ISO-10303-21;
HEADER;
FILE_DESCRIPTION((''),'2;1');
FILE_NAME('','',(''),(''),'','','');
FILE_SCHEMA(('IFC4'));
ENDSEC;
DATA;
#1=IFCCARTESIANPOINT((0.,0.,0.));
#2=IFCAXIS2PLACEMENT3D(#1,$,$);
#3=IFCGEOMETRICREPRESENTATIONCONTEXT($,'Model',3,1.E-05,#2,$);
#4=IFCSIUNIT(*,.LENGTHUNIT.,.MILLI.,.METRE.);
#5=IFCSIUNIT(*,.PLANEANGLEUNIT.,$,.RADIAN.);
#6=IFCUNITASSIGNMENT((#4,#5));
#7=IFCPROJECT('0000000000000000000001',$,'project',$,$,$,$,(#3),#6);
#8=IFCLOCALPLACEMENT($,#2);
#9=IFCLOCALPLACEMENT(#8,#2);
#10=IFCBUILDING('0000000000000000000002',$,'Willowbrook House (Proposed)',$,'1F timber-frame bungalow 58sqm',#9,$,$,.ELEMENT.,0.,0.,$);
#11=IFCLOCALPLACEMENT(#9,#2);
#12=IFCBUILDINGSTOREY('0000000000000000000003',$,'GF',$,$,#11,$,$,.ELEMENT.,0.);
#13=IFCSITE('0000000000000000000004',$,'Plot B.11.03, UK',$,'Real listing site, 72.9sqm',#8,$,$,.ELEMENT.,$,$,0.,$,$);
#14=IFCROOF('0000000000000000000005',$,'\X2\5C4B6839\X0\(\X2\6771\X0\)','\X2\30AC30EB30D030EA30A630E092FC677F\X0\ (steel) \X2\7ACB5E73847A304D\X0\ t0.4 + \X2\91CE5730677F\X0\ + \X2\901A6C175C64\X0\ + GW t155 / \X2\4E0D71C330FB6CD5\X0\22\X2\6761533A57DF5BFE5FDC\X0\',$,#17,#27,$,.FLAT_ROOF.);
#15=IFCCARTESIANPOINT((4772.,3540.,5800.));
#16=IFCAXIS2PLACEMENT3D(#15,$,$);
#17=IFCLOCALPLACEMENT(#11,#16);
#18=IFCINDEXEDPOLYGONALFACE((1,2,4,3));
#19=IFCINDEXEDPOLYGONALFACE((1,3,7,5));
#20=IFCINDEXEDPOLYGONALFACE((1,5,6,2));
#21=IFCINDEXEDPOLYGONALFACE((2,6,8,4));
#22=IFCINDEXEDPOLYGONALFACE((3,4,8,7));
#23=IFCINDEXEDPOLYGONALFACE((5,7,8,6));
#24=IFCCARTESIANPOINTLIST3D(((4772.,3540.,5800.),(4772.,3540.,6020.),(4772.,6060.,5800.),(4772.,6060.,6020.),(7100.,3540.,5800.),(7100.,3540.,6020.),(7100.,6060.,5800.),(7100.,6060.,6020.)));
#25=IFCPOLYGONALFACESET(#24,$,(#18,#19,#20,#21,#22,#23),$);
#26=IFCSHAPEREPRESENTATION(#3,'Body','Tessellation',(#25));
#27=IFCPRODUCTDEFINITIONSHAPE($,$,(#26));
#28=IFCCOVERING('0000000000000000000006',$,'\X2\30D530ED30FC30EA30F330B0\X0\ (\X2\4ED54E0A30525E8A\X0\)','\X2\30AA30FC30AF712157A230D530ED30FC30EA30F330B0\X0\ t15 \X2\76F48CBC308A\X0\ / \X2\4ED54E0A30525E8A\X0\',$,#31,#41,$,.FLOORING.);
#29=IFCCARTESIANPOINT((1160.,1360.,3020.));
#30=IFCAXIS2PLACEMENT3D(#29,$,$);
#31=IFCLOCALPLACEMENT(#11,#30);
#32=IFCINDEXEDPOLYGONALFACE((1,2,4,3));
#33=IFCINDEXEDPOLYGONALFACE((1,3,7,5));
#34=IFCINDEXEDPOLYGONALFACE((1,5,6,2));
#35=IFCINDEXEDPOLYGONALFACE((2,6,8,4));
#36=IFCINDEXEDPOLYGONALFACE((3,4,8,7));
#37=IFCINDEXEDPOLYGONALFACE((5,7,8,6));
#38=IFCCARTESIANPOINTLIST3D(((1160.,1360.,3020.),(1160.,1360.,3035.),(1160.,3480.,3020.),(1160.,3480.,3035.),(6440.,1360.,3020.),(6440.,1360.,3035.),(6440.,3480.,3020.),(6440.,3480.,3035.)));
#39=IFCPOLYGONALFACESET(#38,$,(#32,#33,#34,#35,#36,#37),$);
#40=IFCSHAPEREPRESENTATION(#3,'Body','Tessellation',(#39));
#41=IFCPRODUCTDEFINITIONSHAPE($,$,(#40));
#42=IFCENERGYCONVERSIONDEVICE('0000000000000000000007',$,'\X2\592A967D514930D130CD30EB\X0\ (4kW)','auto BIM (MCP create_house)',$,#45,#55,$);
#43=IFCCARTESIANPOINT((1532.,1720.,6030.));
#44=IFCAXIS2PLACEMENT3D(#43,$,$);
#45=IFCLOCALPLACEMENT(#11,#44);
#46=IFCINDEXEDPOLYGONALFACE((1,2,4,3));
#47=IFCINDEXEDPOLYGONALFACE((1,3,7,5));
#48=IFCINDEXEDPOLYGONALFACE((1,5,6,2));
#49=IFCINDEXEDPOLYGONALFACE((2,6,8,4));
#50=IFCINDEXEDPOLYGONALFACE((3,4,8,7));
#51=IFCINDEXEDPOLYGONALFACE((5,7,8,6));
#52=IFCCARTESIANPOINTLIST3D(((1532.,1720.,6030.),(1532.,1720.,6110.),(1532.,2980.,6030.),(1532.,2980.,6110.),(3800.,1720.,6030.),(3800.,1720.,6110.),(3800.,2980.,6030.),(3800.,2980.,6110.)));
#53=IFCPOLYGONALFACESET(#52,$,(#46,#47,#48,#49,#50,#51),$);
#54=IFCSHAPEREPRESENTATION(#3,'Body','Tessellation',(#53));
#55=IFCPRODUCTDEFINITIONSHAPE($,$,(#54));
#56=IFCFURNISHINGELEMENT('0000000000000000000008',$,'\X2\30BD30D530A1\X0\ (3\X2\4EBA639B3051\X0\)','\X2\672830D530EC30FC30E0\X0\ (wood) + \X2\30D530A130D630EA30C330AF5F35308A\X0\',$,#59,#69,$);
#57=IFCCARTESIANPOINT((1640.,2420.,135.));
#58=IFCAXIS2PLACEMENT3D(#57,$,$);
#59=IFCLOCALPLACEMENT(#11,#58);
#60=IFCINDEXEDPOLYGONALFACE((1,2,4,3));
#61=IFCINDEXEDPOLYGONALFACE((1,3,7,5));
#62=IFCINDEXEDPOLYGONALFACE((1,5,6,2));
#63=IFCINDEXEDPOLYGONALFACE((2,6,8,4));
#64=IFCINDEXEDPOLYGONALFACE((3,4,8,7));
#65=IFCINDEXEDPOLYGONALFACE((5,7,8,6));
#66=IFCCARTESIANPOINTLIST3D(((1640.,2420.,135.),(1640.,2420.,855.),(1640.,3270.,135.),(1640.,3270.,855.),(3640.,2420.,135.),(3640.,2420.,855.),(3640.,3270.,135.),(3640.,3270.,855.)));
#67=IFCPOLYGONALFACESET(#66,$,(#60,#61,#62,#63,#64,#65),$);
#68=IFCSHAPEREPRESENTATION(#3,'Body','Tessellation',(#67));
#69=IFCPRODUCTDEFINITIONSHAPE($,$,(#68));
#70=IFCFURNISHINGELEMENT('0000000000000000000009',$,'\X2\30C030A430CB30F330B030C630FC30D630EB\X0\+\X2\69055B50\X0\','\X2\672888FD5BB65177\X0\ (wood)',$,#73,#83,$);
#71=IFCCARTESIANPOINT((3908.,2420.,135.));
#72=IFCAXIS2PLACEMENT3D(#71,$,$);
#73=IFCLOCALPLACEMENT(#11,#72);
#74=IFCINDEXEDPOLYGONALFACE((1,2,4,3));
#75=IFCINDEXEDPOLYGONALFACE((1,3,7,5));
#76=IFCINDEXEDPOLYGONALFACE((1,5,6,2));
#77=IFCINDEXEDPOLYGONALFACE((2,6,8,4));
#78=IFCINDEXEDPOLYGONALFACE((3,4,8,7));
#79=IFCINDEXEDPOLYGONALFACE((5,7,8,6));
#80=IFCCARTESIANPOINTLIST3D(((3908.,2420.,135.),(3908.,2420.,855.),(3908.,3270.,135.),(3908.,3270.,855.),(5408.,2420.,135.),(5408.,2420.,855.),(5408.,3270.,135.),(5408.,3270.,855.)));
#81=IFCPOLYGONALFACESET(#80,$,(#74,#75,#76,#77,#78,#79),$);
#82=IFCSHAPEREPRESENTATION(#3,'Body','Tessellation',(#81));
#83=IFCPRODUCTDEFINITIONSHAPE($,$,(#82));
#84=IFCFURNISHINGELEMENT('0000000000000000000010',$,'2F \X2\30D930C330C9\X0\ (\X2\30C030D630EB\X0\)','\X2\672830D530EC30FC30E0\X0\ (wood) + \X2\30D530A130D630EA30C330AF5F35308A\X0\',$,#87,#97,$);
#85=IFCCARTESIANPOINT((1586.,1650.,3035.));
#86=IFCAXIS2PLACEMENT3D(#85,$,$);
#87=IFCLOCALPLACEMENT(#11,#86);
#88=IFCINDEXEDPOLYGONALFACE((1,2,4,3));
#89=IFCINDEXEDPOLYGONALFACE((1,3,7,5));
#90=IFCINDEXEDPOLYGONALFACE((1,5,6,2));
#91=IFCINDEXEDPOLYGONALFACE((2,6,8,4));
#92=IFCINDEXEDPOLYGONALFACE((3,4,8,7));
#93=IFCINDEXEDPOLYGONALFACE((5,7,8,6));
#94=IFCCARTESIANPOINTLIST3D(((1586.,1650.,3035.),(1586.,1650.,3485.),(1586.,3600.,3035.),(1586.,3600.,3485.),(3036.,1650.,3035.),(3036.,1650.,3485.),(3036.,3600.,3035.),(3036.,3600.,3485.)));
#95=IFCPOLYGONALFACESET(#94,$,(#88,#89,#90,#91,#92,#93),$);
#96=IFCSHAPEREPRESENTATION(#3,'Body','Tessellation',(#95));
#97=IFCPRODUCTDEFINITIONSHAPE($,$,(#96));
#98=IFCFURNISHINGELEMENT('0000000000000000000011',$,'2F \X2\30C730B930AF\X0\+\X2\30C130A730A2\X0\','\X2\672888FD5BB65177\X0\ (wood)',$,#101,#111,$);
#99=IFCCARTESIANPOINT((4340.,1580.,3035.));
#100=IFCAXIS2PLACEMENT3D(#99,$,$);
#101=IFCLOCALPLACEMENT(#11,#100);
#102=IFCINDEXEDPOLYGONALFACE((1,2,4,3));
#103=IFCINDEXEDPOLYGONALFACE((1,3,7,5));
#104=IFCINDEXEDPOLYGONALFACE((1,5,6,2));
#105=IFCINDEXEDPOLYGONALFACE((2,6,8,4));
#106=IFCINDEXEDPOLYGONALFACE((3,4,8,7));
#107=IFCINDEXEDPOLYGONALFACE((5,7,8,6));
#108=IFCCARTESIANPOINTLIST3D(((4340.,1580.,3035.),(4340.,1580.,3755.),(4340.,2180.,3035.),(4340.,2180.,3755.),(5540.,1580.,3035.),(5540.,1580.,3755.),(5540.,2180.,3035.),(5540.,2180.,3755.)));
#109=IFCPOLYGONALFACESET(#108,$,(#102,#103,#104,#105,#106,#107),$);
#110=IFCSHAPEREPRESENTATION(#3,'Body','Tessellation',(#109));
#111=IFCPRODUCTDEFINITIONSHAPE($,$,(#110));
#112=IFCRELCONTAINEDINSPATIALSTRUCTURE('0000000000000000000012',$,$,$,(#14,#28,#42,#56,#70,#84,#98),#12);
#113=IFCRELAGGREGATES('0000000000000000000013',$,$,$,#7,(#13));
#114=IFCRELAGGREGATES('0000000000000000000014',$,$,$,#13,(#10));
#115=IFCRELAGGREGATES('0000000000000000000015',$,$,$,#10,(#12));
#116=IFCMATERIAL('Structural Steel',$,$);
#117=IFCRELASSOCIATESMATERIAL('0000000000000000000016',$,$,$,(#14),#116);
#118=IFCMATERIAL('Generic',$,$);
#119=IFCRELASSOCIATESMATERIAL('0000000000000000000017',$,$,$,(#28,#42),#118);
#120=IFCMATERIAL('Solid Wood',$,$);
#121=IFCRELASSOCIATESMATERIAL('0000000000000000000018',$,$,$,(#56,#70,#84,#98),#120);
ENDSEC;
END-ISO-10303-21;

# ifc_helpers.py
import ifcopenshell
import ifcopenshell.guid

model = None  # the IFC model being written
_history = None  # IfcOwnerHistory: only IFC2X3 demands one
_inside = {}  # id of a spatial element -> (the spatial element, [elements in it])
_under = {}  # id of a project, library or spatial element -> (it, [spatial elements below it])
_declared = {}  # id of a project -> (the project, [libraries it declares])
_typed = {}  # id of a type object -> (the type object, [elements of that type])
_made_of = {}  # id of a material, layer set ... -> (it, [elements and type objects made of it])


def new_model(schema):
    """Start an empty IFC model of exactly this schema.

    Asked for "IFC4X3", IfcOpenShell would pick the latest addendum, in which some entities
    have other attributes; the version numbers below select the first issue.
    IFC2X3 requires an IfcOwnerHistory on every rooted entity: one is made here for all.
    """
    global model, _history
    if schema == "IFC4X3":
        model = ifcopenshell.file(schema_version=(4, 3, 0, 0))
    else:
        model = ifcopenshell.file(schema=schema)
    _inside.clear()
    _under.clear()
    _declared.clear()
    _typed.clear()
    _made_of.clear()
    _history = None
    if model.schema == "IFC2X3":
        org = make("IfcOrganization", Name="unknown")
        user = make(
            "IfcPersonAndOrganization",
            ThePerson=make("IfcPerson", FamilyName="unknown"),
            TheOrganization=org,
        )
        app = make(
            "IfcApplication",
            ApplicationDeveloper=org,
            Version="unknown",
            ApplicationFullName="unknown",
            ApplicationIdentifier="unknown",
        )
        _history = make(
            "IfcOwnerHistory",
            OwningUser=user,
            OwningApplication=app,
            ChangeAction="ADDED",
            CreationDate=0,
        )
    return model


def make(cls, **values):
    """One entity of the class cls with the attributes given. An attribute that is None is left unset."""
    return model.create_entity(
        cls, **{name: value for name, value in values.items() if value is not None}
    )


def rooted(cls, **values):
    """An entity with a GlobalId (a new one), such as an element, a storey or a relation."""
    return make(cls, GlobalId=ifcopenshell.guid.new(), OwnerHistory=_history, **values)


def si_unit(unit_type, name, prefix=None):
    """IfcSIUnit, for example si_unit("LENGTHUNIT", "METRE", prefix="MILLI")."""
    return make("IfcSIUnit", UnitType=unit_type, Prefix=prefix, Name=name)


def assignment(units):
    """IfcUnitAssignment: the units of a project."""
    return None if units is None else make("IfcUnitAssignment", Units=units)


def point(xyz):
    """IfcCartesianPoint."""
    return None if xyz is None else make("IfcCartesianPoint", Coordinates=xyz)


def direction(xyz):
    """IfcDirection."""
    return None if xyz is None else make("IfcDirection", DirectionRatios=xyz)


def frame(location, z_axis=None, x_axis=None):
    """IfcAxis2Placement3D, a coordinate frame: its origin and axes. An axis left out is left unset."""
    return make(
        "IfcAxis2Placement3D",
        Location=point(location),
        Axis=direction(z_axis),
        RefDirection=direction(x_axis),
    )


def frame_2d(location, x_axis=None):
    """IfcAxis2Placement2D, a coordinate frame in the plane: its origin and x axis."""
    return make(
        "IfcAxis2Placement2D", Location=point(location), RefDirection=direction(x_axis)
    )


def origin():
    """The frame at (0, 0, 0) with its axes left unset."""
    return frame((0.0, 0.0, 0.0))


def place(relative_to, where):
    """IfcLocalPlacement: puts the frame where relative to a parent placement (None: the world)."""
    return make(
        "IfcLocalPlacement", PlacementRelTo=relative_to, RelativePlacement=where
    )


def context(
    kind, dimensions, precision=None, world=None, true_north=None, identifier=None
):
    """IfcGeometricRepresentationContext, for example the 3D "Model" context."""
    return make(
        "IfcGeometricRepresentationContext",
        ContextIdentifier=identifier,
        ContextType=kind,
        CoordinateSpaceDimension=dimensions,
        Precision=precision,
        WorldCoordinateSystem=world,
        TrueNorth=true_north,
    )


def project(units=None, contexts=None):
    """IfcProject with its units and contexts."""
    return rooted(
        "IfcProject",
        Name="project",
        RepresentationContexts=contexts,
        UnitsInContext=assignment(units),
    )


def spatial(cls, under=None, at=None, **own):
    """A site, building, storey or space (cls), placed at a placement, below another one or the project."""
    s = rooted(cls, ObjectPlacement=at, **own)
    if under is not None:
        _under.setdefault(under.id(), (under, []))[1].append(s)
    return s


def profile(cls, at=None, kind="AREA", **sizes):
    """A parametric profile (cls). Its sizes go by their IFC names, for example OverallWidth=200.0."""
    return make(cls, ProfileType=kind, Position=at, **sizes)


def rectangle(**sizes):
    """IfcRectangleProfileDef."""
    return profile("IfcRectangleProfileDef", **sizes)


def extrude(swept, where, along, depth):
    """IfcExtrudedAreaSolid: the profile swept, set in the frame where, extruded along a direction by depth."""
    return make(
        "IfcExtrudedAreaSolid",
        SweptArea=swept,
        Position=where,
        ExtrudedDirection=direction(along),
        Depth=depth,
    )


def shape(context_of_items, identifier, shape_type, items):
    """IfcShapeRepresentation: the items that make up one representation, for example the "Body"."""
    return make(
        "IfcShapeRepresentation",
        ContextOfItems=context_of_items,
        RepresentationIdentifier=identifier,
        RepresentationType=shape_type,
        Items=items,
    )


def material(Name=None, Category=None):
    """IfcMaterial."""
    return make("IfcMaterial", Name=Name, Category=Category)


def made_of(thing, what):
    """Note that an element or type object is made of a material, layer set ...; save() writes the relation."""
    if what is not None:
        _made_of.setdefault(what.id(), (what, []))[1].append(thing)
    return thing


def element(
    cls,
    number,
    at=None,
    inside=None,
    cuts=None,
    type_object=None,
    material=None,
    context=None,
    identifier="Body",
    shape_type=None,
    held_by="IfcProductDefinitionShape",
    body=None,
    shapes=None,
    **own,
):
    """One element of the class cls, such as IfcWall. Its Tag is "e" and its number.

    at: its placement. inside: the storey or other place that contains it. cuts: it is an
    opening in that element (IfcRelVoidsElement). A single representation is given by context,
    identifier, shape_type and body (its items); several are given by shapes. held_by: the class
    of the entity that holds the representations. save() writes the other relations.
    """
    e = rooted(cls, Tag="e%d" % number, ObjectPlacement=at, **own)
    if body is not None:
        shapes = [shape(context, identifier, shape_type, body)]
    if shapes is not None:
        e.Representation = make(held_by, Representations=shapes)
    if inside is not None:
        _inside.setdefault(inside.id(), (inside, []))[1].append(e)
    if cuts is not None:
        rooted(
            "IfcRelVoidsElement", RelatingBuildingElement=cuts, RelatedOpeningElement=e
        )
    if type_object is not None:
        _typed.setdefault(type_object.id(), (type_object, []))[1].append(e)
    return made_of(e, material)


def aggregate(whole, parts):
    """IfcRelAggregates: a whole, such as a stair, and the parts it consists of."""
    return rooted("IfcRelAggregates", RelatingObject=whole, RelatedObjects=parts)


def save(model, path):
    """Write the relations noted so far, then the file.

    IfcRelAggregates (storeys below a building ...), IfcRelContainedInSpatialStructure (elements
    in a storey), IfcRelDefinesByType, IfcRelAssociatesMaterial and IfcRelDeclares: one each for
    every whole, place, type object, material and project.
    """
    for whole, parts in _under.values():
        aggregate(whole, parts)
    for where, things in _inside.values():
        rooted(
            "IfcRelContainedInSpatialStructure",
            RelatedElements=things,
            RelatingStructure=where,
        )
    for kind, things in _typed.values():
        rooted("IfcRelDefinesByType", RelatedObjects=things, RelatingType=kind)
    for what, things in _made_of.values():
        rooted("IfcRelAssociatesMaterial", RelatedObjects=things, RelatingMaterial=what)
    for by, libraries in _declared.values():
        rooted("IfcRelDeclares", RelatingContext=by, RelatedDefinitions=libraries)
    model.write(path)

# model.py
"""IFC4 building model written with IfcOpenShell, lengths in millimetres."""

from ifc_helpers import new_model, si_unit, frame, frame_2d, origin, place, context, project, spatial, rectangle, extrude, material, element, save


model = new_model("IFC4")

# Units and contexts
model_context = context("Model", 3, precision=1e-05, world=origin())
ifc_project = project(units=[si_unit("LENGTHUNIT", "METRE", prefix="MILLI"), si_unit("PLANEANGLEUNIT", "RADIAN")], contexts=[model_context])

# Site, building, storey
site_placement = place(None, origin())
site = spatial("IfcSite", under=ifc_project, at=site_placement, Name="Plot B.11.03, UK", ObjectType="Real listing site, 72.9sqm", CompositionType="ELEMENT", RefElevation=0.0)
building_placement = place(site_placement, origin())
building = spatial("IfcBuilding", under=site, at=building_placement, Name="Willowbrook House (Proposed)", ObjectType="1F timber-frame bungalow 58sqm", CompositionType="ELEMENT", ElevationOfRefHeight=0.0, ElevationOfTerrain=0.0)
storey_placement = place(building_placement, origin())
storey = spatial("IfcBuildingStorey", under=building, at=storey_placement, Name="GF", CompositionType="ELEMENT", Elevation=0.0)

# Shared definitions
ifc_material_1 = material(Name="Solid Wood")

# Roof
ifc_material_2 = material(Name="Structural Steel")
roof_1_placement = place(storey_placement, frame((4772.0, 3540.0, 5800.0)))
element("IfcRoof", 1, at=roof_1_placement, inside=storey, material=ifc_material_2, Name="屋根(東)", Description="ガルバリウム鋼板 (steel) 立平葺き t0.4 + 野地板 + 通気層 + GW t155 / 不燃・法22条区域対応", PredefinedType="FLAT_ROOF", context=model_context, shape_type="SweptSolid", body=[
    extrude(rectangle(XDim=2328.0, YDim=2520.0, at=frame_2d((1164.0, 1260.0))), frame((4772.0, 3540.0, 5800.0)), (0.0, 0.0, 1.0), 220.0),
])

# Covering
ifc_material_3 = material(Name="Generic")
covering_placement = place(storey_placement, frame((1160.0, 1360.0, 3020.0)))
element("IfcCovering", 2, at=covering_placement, inside=storey, material=ifc_material_3, Name="フローリング (仕上げ床)", Description="オーク無垢フローリング t15 直貼り / 仕上げ床", PredefinedType="FLOORING", context=model_context, shape_type="SweptSolid", body=[
    extrude(rectangle(XDim=5280.0, YDim=2120.0, at=frame_2d((2640.0, 1060.0))), frame((1160.0, 1360.0, 3020.0)), (0.0, 0.0, 1.0), 15.0),
])

# Energy conversion device
energy_conversion_device_placement = place(storey_placement, frame((1532.0, 1720.0, 6030.0)))
element("IfcEnergyConversionDevice", 3, at=energy_conversion_device_placement, inside=storey, material=ifc_material_3, Name="太陽光パネル (4kW)", Description="auto BIM (MCP create_house)", context=model_context, shape_type="SweptSolid", body=[
    extrude(rectangle(XDim=2268.0, YDim=1260.0, at=frame_2d((1134.0, 630.0))), frame((1532.0, 1720.0, 6030.0)), (0.0, 0.0, 1.0), 80.0),
])

# Furnishing elements
furnishing_1_placement = place(storey_placement, frame((1640.0, 2420.0, 135.0)))
element("IfcFurnishingElement", 4, at=furnishing_1_placement, inside=storey, material=ifc_material_1, Name="ソファ (3人掛け)", Description="木フレーム (wood) + ファブリック張り", context=model_context, shape_type="SweptSolid", body=[
    extrude(rectangle(XDim=2000.0, YDim=850.0, at=frame_2d((1000.0, 425.0))), frame((1640.0, 2420.0, 135.0)), (0.0, 0.0, 1.0), 720.0),
])
furnishing_2_placement = place(storey_placement, frame((3908.0, 2420.0, 135.0)))
element("IfcFurnishingElement", 5, at=furnishing_2_placement, inside=storey, material=ifc_material_1, Name="ダイニングテーブル+椅子", Description="木製家具 (wood)", context=model_context, shape_type="SweptSolid", body=[
    extrude(rectangle(XDim=1500.0, YDim=850.0, at=frame_2d((750.0, 425.0))), frame((3908.0, 2420.0, 135.0)), (0.0, 0.0, 1.0), 720.0),
])
furnishing_3_placement = place(storey_placement, frame((1586.0, 1650.0, 3035.0)))
element("IfcFurnishingElement", 6, at=furnishing_3_placement, inside=storey, material=ifc_material_1, Name="2F ベッド (ダブル)", Description="木フレーム (wood) + ファブリック張り", context=model_context, shape_type="SweptSolid", body=[
    extrude(rectangle(XDim=1450.0, YDim=1950.0, at=frame_2d((725.0, 975.0))), frame((1586.0, 1650.0, 3035.0)), (0.0, 0.0, 1.0), 450.0),
])
furnishing_4_placement = place(storey_placement, frame((4340.0, 1580.0, 3035.0)))
element("IfcFurnishingElement", 7, at=furnishing_4_placement, inside=storey, material=ifc_material_1, Name="2F デスク+チェア", Description="木製家具 (wood)", context=model_context, shape_type="SweptSolid", body=[
    extrude(rectangle(XDim=1200.0, YDim=600.0, at=frame_2d((600.0, 300.0))), frame((4340.0, 1580.0, 3035.0)), (0.0, 0.0, 1.0), 720.0),
])

save(model, "model.ifc")
